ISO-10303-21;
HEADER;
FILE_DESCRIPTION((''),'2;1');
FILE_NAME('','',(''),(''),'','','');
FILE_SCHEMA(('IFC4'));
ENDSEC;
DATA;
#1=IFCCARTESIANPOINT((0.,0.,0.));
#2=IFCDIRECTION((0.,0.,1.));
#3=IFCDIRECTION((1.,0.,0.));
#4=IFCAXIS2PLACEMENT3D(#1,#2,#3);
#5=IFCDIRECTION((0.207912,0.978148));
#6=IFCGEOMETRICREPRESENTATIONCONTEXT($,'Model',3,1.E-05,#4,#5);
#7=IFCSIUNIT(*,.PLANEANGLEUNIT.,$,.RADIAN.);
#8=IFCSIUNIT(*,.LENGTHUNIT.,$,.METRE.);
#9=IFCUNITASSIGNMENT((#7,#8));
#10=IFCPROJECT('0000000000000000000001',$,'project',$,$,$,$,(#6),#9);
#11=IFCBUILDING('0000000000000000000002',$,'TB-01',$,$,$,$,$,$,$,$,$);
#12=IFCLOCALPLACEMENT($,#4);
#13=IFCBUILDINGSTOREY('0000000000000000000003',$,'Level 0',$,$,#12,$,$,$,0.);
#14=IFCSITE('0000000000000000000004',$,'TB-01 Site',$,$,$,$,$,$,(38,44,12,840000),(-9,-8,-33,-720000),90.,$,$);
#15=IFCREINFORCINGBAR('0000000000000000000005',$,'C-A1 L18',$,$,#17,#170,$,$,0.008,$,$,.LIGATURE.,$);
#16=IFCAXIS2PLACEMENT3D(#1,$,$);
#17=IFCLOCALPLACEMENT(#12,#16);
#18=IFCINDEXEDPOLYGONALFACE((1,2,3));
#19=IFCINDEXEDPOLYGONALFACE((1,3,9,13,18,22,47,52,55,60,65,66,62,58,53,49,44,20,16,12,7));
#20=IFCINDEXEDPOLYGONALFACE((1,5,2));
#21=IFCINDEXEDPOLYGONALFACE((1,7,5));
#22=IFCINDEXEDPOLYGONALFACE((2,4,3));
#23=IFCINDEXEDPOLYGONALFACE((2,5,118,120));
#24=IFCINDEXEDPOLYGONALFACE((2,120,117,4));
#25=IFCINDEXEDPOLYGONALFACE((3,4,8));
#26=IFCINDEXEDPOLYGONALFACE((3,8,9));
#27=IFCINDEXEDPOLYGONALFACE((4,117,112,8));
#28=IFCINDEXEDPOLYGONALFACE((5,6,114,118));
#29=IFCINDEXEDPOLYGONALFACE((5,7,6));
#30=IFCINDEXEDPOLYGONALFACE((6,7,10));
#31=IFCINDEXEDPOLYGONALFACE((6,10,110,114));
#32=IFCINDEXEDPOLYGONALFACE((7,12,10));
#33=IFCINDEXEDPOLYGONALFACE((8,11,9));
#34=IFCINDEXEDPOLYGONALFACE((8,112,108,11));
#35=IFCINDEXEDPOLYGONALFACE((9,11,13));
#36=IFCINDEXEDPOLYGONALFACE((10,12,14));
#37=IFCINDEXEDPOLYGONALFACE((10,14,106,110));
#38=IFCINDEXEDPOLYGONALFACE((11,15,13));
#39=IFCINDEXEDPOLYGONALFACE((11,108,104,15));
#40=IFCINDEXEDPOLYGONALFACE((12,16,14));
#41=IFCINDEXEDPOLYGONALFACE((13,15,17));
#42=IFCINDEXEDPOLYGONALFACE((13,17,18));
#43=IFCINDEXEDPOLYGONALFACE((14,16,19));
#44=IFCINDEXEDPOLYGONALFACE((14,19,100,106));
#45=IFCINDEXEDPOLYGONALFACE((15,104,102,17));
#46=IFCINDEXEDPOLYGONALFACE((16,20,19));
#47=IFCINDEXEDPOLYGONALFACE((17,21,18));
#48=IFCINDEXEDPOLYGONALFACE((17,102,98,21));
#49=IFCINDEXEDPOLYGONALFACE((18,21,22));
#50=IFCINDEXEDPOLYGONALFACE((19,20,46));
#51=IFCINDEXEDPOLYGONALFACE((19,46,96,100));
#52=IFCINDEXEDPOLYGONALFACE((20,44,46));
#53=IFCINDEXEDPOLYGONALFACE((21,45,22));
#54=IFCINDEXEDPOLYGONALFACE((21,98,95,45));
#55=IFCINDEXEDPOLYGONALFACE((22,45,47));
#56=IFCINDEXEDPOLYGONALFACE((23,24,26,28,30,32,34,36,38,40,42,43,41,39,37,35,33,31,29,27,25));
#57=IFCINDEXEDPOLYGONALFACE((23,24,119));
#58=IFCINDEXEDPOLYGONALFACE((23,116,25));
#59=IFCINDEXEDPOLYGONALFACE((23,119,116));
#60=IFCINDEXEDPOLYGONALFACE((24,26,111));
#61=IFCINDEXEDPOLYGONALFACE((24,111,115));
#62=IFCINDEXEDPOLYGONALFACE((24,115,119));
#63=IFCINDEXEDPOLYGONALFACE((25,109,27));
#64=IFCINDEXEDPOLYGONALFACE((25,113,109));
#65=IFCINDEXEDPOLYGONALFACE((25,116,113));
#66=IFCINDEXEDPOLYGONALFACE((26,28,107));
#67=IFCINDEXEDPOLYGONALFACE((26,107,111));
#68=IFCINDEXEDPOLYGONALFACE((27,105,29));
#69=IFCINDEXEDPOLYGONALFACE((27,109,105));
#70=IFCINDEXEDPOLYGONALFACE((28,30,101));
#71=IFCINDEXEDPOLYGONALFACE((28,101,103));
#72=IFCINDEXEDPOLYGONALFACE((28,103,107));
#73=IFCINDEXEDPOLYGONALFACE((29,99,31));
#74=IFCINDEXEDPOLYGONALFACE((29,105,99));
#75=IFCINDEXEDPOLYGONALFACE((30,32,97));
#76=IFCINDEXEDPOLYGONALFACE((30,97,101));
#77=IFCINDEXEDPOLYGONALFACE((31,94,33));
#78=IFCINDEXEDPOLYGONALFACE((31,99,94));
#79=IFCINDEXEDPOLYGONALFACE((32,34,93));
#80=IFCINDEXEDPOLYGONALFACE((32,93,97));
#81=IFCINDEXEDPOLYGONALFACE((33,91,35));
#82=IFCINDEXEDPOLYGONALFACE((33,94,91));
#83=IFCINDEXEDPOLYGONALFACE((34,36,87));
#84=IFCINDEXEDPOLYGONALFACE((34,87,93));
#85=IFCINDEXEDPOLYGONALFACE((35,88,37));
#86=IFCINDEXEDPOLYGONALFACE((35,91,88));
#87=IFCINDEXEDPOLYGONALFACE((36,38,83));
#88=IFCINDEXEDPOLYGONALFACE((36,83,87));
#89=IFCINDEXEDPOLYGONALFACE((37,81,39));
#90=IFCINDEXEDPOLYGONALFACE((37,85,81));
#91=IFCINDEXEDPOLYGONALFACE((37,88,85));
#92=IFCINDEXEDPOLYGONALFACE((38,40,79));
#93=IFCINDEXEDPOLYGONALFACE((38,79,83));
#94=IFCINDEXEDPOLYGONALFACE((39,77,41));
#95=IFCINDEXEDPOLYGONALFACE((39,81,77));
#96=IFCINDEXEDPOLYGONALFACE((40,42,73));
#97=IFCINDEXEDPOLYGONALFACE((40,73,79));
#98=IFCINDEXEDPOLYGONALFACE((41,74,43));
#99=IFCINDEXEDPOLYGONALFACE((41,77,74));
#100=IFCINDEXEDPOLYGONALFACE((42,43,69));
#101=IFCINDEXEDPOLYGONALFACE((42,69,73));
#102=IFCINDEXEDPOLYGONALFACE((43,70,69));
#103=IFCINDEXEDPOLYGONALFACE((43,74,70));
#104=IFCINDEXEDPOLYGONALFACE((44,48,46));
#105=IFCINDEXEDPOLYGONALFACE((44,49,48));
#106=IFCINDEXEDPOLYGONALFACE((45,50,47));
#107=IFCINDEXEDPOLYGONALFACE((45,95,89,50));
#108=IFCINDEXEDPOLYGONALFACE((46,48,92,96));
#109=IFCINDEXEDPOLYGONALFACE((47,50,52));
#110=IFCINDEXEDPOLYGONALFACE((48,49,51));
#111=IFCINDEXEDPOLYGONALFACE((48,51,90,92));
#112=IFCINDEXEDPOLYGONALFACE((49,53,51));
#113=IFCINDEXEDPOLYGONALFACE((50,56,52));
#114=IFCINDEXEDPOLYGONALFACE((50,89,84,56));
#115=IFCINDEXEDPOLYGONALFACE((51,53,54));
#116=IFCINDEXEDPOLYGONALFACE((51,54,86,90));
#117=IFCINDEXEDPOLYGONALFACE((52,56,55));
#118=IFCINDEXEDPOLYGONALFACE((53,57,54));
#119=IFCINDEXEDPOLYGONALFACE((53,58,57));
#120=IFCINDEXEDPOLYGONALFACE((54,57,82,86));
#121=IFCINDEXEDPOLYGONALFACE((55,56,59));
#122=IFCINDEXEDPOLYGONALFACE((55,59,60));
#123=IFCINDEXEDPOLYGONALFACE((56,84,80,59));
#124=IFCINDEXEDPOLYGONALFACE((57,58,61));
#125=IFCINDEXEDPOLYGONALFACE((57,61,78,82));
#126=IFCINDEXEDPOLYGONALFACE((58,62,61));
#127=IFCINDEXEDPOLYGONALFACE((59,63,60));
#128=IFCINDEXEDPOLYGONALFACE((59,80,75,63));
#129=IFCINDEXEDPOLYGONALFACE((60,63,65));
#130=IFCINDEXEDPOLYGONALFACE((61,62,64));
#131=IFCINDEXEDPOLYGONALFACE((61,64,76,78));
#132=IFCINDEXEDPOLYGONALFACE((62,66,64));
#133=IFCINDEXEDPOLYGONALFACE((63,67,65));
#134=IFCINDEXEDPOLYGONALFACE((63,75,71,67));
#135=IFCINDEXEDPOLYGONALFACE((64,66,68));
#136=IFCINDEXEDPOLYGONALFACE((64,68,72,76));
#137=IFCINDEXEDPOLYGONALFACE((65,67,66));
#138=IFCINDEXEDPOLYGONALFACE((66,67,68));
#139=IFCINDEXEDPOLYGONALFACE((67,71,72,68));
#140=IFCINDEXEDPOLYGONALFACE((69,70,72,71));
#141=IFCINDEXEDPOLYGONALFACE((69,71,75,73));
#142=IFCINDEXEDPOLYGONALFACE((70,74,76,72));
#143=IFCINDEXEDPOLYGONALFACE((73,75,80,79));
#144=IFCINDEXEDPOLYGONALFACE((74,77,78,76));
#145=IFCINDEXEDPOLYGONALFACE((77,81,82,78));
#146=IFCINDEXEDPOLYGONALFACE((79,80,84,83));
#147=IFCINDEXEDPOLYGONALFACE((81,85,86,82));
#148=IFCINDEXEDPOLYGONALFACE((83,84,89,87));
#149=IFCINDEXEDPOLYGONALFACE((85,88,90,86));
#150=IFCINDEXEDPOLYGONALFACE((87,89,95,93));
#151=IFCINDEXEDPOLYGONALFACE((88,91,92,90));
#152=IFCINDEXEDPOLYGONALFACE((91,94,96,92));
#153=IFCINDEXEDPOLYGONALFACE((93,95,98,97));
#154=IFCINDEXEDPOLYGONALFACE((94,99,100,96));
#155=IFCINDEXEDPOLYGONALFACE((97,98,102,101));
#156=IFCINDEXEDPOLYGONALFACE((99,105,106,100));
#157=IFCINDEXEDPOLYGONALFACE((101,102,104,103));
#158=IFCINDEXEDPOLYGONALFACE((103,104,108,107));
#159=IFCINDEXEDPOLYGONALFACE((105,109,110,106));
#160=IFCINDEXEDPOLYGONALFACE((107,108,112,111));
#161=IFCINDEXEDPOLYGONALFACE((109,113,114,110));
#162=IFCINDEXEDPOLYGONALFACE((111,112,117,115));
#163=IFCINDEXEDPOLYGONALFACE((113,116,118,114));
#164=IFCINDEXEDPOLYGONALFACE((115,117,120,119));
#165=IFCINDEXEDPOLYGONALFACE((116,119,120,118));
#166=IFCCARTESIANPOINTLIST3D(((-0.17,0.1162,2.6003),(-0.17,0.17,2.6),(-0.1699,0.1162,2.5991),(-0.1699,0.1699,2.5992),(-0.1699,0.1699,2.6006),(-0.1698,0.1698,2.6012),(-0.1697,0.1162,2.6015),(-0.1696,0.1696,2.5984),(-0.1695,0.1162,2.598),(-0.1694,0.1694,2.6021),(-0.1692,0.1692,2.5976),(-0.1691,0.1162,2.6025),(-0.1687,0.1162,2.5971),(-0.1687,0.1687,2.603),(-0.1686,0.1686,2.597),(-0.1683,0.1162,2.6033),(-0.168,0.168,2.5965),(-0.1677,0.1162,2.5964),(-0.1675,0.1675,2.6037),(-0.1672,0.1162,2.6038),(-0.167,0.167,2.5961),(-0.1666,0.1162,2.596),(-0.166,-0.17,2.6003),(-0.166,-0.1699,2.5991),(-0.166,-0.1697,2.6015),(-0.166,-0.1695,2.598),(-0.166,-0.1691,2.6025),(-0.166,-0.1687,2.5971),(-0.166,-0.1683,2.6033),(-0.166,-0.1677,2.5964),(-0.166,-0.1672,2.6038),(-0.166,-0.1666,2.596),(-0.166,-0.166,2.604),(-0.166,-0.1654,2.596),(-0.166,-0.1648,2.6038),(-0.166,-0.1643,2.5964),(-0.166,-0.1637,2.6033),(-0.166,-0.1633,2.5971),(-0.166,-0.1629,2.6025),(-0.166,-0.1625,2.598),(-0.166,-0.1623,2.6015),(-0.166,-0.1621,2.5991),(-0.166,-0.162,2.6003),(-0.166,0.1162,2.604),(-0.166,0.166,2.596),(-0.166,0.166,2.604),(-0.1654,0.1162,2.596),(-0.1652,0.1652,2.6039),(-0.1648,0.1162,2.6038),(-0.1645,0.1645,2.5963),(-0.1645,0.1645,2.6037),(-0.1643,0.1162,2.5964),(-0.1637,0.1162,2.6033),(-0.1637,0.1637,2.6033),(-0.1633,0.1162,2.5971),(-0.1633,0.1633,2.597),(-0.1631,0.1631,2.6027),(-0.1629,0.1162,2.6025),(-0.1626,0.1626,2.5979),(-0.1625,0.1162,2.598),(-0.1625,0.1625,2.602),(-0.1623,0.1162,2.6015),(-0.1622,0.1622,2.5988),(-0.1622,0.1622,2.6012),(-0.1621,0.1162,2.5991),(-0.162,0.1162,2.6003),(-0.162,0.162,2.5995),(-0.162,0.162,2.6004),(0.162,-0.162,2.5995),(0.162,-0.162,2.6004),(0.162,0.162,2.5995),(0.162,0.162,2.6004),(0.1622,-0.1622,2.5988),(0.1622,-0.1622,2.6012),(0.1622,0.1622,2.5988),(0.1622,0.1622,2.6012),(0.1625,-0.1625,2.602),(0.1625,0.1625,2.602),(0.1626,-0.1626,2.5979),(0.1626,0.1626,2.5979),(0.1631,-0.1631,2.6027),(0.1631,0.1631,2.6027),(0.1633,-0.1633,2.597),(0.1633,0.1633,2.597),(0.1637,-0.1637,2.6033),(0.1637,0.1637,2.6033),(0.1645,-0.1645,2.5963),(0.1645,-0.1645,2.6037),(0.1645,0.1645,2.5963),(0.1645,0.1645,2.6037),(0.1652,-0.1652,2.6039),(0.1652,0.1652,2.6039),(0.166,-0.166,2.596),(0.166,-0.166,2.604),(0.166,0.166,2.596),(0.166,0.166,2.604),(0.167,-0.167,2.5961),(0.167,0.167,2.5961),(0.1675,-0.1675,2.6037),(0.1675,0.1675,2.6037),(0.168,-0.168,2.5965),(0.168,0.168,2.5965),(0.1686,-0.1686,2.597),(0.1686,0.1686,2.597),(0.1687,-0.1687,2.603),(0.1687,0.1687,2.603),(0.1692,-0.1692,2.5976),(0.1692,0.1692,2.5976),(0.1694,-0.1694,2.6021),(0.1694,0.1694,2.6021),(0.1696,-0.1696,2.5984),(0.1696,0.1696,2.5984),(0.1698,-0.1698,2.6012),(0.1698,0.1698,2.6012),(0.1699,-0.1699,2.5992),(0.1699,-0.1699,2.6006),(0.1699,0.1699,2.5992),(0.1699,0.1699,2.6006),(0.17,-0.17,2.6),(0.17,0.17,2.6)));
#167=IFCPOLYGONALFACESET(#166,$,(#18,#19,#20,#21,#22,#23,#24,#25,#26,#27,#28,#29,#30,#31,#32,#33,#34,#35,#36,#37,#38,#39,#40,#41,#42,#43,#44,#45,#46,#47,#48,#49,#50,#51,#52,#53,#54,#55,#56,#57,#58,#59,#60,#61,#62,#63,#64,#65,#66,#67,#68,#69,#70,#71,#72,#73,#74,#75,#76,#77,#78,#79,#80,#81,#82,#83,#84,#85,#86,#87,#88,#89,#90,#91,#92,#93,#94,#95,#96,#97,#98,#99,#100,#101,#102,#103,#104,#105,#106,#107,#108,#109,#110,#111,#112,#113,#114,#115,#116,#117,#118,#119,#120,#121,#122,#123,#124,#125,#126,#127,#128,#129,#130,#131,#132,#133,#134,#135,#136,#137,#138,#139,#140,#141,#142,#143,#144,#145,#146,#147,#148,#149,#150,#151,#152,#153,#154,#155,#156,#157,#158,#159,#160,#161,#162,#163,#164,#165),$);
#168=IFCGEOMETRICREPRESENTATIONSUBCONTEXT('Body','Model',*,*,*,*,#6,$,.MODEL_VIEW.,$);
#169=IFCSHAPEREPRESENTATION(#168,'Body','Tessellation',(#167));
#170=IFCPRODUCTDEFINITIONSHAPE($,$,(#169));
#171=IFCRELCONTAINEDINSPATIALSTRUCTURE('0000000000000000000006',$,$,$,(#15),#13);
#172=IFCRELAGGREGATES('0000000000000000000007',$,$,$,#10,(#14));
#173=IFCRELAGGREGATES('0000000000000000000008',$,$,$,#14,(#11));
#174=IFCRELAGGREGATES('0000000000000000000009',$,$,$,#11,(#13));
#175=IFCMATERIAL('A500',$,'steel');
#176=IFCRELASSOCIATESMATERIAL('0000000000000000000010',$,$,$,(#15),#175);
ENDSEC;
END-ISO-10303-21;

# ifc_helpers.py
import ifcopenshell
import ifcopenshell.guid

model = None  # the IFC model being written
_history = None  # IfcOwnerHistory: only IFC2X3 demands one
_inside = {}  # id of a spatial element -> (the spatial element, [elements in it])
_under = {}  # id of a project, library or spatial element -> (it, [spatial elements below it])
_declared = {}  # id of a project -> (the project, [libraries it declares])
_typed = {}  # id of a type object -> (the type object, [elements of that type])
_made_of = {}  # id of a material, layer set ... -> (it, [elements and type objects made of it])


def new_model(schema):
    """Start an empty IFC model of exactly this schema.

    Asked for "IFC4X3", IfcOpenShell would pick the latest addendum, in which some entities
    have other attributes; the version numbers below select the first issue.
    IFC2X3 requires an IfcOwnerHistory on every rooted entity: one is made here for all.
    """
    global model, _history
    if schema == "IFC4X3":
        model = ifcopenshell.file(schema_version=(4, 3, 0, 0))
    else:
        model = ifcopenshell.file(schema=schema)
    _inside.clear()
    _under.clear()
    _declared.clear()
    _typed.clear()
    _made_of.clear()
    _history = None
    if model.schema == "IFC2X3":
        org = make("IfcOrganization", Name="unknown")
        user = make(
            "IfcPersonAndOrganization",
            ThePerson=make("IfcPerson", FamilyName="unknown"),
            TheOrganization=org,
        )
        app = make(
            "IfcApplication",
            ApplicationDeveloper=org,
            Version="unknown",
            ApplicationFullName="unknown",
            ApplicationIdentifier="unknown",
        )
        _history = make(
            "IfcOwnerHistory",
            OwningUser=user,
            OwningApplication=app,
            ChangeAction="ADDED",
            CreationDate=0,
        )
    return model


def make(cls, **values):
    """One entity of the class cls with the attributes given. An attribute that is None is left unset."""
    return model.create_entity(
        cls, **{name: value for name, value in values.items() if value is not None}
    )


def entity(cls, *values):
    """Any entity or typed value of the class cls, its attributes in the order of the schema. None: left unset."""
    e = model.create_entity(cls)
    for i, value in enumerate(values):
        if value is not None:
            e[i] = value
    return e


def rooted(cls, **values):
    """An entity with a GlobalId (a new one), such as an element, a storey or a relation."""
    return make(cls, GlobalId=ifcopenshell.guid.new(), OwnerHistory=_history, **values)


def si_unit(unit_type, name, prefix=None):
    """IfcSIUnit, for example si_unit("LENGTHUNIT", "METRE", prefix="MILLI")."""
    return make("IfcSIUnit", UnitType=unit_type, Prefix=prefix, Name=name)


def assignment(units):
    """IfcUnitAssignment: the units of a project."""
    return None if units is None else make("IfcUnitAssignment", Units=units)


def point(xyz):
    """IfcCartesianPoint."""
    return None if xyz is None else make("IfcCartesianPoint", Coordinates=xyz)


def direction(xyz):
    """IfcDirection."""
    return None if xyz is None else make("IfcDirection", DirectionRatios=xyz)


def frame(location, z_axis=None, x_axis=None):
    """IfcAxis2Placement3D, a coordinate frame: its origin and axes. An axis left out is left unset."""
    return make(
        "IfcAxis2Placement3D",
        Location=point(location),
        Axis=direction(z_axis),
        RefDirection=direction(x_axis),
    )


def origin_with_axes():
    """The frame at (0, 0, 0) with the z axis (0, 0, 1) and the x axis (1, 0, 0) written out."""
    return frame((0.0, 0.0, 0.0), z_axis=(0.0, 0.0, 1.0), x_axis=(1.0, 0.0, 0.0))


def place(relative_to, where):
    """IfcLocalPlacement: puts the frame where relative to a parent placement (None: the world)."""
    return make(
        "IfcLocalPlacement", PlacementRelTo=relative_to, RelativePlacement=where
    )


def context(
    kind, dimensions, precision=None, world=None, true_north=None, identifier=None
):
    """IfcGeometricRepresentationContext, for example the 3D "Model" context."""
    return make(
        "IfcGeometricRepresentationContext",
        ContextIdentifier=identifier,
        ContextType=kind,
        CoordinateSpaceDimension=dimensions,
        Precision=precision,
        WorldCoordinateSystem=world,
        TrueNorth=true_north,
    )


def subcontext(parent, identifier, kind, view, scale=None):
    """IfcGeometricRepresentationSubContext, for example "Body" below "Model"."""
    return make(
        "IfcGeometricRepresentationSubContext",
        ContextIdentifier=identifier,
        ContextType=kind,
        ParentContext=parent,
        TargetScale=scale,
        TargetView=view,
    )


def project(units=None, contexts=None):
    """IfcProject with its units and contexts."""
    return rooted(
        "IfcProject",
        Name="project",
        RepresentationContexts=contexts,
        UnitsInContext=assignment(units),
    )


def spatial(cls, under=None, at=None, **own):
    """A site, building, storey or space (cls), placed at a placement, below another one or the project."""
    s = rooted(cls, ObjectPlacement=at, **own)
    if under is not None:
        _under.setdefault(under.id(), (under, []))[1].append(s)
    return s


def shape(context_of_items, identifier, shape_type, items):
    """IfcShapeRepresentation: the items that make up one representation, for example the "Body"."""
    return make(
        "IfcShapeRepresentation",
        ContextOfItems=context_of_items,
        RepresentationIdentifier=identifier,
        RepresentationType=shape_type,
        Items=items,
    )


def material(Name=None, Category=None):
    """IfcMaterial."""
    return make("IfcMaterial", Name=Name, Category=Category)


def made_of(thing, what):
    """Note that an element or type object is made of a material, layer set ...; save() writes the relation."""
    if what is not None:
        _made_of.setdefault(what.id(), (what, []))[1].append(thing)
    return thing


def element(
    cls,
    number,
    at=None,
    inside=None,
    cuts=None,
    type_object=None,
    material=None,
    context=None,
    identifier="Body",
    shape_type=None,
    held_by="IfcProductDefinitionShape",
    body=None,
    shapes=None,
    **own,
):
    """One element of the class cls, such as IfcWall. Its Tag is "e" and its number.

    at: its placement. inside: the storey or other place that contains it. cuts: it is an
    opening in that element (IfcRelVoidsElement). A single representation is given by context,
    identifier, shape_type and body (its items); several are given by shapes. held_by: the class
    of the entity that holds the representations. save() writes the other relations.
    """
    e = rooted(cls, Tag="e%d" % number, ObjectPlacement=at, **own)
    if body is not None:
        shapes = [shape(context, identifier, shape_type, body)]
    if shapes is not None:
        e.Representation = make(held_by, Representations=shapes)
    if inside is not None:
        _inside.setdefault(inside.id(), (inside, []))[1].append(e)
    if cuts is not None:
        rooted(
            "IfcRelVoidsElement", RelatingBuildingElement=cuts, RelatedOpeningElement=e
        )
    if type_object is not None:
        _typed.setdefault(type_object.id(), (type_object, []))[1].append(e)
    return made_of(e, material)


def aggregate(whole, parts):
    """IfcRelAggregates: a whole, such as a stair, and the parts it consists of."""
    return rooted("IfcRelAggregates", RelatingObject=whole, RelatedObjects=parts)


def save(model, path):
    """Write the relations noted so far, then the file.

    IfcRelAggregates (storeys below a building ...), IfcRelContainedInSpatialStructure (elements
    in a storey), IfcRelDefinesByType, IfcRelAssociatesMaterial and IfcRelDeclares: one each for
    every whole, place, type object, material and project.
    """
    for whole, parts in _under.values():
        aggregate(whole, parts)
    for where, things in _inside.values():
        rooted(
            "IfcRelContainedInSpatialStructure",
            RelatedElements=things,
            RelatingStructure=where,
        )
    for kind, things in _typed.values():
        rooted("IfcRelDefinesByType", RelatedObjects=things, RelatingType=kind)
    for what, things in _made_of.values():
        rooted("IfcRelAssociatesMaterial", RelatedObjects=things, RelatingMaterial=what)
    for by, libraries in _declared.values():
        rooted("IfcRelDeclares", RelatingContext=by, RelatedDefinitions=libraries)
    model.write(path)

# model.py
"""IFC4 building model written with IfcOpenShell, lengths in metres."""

from ifc_helpers import new_model, entity, si_unit, direction, origin_with_axes, place, context, subcontext, project, spatial, material, element, save


model = new_model("IFC4")

# Units and contexts
model_context = context("Model", 3, precision=1e-05, world=origin_with_axes(), true_north=direction((0.207912, 0.978148)))
body_context = subcontext(model_context, "Body", "Model", "MODEL_VIEW")
ifc_project = project(units=[si_unit("PLANEANGLEUNIT", "RADIAN"), si_unit("LENGTHUNIT", "METRE")], contexts=[model_context])

# Site, building, storey
site = spatial("IfcSite", under=ifc_project, Name="TB-01 Site", RefLatitude=(38, 44, 12, 840000), RefLongitude=(-9, -8, -33, -720000), RefElevation=90.0)
building = spatial("IfcBuilding", under=site, Name="TB-01")
storey_placement = place(None, origin_with_axes())
storey = spatial("IfcBuildingStorey", under=building, at=storey_placement, Name="Level 0", Elevation=0.0)

# Reinforcing bar
ifc_material_1 = material(Name="A500", Category="steel")
reinforcing_bar_1_placement = place(storey_placement, origin_with_axes())
element("IfcReinforcingBar", 1, at=reinforcing_bar_1_placement, inside=storey, material=ifc_material_1, Name="C-A1 L18", NominalDiameter=0.008, PredefinedType="LIGATURE", context=body_context, shape_type="AdvancedSweptSolid", body=[
    entity("IfcSweptDiskSolid", entity("IfcPolyline", [entity("IfcCartesianPoint", [-0.166, -0.166, 2.6]), entity("IfcCartesianPoint", [0.166, -0.166, 2.6]), entity("IfcCartesianPoint", [0.166, 0.166, 2.6]), entity("IfcCartesianPoint", [-0.166, 0.166, 2.6]), entity("IfcCartesianPoint", [-0.166, 0.1162, 2.6])]), 0.004),
])

save(model, "model.ifc")
